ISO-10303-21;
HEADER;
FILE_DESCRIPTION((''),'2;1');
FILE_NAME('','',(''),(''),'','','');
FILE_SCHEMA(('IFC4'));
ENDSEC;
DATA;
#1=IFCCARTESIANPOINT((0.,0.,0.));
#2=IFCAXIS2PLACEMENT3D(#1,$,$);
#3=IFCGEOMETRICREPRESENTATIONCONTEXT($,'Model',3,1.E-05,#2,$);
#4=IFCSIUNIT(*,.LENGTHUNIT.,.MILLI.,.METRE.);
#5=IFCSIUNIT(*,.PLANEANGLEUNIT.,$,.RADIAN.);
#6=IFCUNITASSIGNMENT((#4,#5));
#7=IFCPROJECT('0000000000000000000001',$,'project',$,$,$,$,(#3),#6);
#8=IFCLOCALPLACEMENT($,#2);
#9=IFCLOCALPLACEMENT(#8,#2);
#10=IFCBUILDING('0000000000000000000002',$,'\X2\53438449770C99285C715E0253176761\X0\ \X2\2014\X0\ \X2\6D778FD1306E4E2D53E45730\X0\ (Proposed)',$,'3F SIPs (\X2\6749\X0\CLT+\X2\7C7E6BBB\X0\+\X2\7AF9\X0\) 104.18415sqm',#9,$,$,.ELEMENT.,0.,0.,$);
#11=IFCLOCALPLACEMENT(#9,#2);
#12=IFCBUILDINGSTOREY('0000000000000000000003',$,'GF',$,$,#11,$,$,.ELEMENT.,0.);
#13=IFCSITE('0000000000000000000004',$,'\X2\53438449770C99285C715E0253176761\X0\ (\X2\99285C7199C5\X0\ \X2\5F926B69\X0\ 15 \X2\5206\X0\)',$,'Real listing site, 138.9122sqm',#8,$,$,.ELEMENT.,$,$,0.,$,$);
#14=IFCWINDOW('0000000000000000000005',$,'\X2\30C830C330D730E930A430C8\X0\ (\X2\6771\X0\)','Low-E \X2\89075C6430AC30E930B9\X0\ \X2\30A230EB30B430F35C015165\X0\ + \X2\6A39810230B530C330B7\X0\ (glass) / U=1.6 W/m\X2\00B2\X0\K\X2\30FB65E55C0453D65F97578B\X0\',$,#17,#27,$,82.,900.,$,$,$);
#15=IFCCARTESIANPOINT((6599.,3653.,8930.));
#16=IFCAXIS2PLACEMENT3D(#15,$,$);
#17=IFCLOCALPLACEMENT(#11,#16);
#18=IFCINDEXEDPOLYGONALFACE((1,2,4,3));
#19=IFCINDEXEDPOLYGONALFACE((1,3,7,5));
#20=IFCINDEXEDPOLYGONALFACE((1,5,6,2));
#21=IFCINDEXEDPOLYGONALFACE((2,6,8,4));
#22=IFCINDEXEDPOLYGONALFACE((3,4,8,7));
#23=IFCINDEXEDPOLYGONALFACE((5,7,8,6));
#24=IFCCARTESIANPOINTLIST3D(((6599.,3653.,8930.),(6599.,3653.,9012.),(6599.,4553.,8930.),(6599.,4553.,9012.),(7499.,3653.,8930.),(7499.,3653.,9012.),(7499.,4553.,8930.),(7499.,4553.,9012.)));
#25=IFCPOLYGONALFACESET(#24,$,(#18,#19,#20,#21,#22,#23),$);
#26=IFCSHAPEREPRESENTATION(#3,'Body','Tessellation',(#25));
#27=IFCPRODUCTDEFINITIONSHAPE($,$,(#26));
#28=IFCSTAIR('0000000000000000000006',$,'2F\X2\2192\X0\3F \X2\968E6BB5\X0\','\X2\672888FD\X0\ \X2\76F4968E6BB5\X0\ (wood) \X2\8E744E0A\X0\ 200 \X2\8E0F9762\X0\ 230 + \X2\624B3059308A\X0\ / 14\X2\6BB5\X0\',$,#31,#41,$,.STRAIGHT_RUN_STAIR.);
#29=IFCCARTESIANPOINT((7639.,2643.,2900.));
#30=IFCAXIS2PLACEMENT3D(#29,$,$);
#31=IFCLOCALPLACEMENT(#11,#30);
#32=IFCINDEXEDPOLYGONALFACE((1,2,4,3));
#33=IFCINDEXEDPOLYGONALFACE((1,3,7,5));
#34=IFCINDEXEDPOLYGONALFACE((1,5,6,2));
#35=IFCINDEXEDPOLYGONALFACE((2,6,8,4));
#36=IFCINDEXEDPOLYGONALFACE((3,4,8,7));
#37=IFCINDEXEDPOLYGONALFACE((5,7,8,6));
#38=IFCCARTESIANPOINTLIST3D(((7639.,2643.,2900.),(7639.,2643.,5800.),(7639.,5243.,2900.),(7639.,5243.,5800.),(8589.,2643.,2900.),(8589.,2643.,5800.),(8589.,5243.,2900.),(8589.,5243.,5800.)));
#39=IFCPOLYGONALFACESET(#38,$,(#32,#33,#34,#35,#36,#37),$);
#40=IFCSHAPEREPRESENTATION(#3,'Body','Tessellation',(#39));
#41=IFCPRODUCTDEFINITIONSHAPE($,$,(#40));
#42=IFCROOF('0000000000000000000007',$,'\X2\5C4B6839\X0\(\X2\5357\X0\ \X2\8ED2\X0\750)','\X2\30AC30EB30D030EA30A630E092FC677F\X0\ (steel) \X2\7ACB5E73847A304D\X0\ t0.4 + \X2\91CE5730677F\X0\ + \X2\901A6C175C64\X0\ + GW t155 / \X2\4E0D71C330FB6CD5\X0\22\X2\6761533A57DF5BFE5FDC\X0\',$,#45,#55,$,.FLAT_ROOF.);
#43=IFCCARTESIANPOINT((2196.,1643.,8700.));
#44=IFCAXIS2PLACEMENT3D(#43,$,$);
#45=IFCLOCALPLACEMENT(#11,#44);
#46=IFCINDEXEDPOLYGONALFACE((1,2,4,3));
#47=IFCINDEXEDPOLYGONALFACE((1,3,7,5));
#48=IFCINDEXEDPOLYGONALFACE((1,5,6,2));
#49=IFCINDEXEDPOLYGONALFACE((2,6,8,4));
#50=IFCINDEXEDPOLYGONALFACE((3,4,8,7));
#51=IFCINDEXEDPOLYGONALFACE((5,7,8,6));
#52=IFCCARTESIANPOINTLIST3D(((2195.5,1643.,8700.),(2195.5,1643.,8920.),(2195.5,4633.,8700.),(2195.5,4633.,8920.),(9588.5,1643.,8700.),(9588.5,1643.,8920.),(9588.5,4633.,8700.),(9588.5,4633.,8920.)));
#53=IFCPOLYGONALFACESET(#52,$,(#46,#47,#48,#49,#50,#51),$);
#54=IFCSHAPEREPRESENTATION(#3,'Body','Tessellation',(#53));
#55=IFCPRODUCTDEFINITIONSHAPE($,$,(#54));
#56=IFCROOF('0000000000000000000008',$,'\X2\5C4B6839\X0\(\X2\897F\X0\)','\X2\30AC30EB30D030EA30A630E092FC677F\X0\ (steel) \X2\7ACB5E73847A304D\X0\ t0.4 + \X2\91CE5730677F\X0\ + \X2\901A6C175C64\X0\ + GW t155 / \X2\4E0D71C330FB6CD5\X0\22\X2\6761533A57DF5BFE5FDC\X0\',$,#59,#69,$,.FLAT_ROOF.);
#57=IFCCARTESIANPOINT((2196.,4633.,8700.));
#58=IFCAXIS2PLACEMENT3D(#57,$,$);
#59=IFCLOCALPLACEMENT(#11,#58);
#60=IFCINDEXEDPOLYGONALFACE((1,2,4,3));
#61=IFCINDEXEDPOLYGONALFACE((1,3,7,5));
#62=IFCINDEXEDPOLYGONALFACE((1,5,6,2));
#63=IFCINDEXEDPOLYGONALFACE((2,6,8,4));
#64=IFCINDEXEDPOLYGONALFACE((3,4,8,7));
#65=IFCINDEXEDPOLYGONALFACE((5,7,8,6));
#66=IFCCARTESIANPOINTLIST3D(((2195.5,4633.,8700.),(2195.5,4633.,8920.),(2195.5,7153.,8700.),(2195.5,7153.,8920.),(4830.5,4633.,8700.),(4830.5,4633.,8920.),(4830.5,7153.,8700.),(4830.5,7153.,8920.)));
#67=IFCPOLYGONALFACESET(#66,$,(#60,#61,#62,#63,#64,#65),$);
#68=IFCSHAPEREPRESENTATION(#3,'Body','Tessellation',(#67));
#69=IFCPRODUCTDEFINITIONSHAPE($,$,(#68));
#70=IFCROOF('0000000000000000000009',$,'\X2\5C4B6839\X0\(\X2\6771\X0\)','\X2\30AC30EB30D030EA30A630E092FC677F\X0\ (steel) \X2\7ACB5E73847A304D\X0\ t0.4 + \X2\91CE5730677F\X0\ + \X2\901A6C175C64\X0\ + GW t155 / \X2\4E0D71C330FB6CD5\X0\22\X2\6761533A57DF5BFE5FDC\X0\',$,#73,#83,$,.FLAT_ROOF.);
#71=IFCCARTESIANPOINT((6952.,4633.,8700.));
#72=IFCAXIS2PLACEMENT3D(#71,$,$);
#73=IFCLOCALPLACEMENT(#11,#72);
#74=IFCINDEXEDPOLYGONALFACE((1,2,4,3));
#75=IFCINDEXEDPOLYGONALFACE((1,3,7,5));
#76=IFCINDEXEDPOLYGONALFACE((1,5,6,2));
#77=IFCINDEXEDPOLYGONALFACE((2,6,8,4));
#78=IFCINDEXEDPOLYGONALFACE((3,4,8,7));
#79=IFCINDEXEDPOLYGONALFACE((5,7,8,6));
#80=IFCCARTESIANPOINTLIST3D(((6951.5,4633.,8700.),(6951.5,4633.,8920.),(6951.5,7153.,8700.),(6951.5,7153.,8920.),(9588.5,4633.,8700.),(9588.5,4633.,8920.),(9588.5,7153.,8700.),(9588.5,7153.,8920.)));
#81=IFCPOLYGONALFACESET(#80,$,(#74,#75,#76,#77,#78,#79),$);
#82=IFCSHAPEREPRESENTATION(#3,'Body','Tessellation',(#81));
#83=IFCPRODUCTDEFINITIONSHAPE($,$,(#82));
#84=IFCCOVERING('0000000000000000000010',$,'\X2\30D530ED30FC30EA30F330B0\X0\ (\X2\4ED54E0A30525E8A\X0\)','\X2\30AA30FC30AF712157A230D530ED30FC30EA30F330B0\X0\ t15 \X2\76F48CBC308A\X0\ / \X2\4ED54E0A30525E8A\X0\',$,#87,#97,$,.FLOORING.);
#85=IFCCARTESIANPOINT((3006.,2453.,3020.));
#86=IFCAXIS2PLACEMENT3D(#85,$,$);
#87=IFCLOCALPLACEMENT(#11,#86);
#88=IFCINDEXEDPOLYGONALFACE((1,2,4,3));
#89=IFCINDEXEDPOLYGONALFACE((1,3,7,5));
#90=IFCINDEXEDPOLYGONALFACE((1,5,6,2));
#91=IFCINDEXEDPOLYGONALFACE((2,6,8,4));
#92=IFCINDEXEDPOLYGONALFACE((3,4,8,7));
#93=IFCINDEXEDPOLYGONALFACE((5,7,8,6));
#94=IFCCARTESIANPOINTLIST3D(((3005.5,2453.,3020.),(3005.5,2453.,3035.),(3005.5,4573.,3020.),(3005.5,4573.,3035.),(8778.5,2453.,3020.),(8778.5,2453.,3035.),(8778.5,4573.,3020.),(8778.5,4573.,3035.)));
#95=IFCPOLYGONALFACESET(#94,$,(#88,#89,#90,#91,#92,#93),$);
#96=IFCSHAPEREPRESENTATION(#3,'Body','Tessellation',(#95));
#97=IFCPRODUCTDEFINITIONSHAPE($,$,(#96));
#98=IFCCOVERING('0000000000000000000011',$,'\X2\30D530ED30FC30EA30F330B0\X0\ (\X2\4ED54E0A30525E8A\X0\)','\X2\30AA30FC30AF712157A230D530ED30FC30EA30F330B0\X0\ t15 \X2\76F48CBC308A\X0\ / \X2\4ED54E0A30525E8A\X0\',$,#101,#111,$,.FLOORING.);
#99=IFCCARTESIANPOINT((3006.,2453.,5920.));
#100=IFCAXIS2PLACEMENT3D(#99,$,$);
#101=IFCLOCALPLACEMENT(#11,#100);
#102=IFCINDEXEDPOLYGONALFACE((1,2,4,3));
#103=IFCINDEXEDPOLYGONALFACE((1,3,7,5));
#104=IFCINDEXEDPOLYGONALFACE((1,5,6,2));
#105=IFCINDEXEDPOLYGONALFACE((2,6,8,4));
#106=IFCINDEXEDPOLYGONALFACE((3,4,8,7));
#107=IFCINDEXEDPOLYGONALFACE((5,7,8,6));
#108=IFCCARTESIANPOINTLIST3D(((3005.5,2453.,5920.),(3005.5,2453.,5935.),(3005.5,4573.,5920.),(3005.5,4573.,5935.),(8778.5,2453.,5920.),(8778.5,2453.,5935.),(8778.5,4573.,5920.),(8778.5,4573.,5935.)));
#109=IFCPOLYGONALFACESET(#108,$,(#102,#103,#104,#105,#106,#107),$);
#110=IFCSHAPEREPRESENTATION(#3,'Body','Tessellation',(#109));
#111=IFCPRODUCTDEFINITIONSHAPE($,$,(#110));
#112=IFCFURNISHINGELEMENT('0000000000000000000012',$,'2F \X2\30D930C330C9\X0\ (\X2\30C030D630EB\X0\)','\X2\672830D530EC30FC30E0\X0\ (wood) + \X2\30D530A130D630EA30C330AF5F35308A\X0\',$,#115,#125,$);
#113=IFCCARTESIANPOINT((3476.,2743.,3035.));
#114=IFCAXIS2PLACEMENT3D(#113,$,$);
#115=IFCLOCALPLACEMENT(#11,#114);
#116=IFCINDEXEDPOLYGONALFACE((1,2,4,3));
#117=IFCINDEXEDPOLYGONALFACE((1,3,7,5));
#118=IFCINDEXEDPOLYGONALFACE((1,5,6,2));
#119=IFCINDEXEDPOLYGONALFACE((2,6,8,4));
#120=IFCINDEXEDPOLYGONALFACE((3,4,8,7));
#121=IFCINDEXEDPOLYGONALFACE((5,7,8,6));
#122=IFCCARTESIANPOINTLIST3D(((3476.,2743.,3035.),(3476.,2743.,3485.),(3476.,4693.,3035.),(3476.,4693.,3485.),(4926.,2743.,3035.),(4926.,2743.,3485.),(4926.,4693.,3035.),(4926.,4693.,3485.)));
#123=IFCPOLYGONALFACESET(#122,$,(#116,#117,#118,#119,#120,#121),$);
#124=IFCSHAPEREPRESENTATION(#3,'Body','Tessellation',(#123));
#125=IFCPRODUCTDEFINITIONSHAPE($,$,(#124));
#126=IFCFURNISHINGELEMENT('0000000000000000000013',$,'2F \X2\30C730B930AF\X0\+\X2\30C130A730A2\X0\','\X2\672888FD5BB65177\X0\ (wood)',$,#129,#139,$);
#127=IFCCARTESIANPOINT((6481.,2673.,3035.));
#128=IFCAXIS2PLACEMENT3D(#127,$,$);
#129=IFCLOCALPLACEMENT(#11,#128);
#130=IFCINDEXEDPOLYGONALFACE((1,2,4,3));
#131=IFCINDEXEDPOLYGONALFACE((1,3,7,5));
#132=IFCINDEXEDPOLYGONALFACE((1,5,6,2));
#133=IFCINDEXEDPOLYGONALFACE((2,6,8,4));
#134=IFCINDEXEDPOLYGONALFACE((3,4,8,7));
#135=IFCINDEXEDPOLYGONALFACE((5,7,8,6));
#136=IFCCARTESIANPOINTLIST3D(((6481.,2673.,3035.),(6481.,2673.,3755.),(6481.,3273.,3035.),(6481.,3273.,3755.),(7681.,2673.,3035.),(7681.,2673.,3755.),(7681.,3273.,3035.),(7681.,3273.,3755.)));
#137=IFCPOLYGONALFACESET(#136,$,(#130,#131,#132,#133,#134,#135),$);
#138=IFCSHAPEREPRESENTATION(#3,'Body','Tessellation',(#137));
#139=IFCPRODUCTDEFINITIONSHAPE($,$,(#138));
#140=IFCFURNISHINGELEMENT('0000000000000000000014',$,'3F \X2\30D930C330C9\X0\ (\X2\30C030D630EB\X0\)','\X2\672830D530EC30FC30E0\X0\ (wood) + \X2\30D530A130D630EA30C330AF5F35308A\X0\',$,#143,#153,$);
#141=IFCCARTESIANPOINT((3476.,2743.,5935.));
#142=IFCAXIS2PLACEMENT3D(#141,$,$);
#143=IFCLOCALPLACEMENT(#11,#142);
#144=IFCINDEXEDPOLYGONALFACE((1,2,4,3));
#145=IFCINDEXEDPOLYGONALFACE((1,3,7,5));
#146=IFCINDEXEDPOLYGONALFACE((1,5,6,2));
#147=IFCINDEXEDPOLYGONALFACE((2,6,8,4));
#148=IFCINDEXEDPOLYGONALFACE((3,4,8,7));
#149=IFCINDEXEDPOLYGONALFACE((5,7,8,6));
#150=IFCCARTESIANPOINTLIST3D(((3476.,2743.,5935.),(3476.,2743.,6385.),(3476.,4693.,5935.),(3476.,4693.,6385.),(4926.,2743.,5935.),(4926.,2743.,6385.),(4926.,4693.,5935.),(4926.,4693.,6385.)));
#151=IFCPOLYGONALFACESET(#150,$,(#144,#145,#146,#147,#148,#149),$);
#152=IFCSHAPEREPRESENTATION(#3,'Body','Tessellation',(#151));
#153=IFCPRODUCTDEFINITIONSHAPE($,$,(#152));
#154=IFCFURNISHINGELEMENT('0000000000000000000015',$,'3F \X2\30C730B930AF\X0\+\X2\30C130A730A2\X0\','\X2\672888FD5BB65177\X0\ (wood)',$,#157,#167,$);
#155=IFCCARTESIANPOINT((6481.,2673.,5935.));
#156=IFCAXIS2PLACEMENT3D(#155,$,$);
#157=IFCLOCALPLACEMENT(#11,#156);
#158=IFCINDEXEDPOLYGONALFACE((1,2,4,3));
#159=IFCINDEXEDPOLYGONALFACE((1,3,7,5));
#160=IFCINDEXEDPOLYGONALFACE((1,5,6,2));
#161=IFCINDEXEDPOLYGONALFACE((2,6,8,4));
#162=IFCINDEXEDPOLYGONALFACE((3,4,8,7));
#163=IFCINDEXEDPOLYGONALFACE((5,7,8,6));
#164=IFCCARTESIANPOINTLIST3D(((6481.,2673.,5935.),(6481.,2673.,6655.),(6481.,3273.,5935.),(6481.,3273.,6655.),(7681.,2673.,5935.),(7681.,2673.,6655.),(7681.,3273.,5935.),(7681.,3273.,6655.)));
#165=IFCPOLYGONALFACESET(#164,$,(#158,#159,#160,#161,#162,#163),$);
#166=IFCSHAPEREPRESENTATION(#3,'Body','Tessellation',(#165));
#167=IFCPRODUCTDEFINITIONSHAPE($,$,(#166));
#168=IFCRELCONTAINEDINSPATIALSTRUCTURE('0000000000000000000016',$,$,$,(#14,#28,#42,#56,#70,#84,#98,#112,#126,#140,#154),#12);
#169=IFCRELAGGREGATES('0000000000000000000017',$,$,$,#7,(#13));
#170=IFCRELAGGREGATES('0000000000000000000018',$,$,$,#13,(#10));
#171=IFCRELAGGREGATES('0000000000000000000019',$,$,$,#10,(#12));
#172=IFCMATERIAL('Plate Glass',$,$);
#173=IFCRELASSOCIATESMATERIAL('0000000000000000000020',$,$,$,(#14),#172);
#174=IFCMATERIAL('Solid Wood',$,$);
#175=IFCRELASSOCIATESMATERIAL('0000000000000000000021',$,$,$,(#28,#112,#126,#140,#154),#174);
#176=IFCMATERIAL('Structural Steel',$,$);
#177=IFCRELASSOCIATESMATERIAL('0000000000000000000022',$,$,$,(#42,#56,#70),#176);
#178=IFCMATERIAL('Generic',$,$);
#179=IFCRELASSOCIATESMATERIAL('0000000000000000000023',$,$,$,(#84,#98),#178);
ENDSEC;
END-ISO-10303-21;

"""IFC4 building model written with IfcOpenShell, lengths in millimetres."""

from ifc_helpers import new_model, si_unit, frame, frame_2d, origin, place, context, project, spatial, rectangle, extrude, material, element, save


model = new_model("IFC4")

# Units and contexts
model_context = context("Model", 3, precision=1e-05, world=origin())
ifc_project = project(units=[si_unit("LENGTHUNIT", "METRE", prefix="MILLI"), si_unit("PLANEANGLEUNIT", "RADIAN")], contexts=[model_context])

# Site, building, storey
site_placement = place(None, origin())
site = spatial("IfcSite", under=ifc_project, at=site_placement, Name="千葉県館山市北条 (館山駅 徒歩 15 分)", ObjectType="Real listing site, 138.9122sqm", CompositionType="ELEMENT", RefElevation=0.0)
building_placement = place(site_placement, origin())
building = spatial("IfcBuilding", under=site, at=building_placement, Name="千葉県館山市北条 — 海近の中古地 (Proposed)", ObjectType="3F SIPs (杉CLT+籾殻+竹) 104.18415sqm", CompositionType="ELEMENT", ElevationOfRefHeight=0.0, ElevationOfTerrain=0.0)
storey_placement = place(building_placement, origin())
storey = spatial("IfcBuildingStorey", under=building, at=storey_placement, Name="GF", CompositionType="ELEMENT", Elevation=0.0)

# Shared definitions
ifc_material_1 = material(Name="Solid Wood")

# Shared definitions
ifc_material_2 = material(Name="Plate Glass")

# Window
window_1_placement = place(storey_placement, frame((6599.0, 3653.0, 8930.0)))
element("IfcWindow", 1, at=window_1_placement, inside=storey, material=ifc_material_2, Name="トップライト (東)", Description="Low-E 複層ガラス アルゴン封入 + 樹脂サッシ (glass) / U=1.6 W/m²K・日射取得型", OverallHeight=82.0, OverallWidth=900.0, context=model_context, shape_type="SweptSolid", body=[
    extrude(rectangle(XDim=900.0, YDim=900.0, at=frame_2d((450.0, 450.0))), frame((6599.0, 3653.0, 8930.0)), (0.0, 0.0, 1.0), 82.0),
])

# Stair
stair_placement = place(storey_placement, frame((7639.0, 2643.0, 2900.0)))
element("IfcStair", 2, at=stair_placement, inside=storey, material=ifc_material_1, Name="2F→3F 階段", Description="木製 直階段 (wood) 蹴上 200 踏面 230 + 手すり / 14段", PredefinedType="STRAIGHT_RUN_STAIR", context=model_context, shape_type="SweptSolid", body=[
    extrude(rectangle(XDim=950.0, YDim=2600.0, at=frame_2d((475.0, 1300.0))), frame((7639.0, 2643.0, 2900.0)), (0.0, 0.0, 1.0), 2900.0),
])

# Roofs
ifc_material_3 = material(Name="Structural Steel")
roof_1_placement = place(storey_placement, frame((2196.0, 1643.0, 8700.0)))
element("IfcRoof", 3, at=roof_1_placement, inside=storey, material=ifc_material_3, Name="屋根(南 軒750)", Description="ガルバリウム鋼板 (steel) 立平葺き t0.4 + 野地板 + 通気層 + GW t155 / 不燃・法22条区域対応", PredefinedType="FLAT_ROOF", context=model_context, shape_type="SweptSolid", body=[
    extrude(rectangle(XDim=7393.0, YDim=2990.0, at=frame_2d((3696.0, 1495.0))), frame((2196.0, 1643.0, 8700.0)), (0.0, 0.0, 1.0), 220.0),
])
roof_2_placement = place(storey_placement, frame((2196.0, 4633.0, 8700.0)))
element("IfcRoof", 4, at=roof_2_placement, inside=storey, material=ifc_material_3, Name="屋根(西)", Description="ガルバリウム鋼板 (steel) 立平葺き t0.4 + 野地板 + 通気層 + GW t155 / 不燃・法22条区域対応", PredefinedType="FLAT_ROOF", context=model_context, shape_type="SweptSolid", body=[
    extrude(rectangle(XDim=2635.0, YDim=2520.0, at=frame_2d((1317.0, 1260.0))), frame((2196.0, 4633.0, 8700.0)), (0.0, 0.0, 1.0), 220.0),
])
roof_3_placement = place(storey_placement, frame((6952.0, 4633.0, 8700.0)))
element("IfcRoof", 5, at=roof_3_placement, inside=storey, material=ifc_material_3, Name="屋根(東)", Description="ガルバリウム鋼板 (steel) 立平葺き t0.4 + 野地板 + 通気層 + GW t155 / 不燃・法22条区域対応", PredefinedType="FLAT_ROOF", context=model_context, shape_type="SweptSolid", body=[
    extrude(rectangle(XDim=2637.0, YDim=2520.0, at=frame_2d((1318.0, 1260.0))), frame((6952.0, 4633.0, 8700.0)), (0.0, 0.0, 1.0), 220.0),
])

# Coverings
ifc_material_4 = material(Name="Generic")
covering_1_placement = place(storey_placement, frame((3006.0, 2453.0, 3020.0)))
element("IfcCovering", 6, at=covering_1_placement, inside=storey, material=ifc_material_4, Name="フローリング (仕上げ床)", Description="オーク無垢フローリング t15 直貼り / 仕上げ床", PredefinedType="FLOORING", context=model_context, shape_type="SweptSolid", body=[
    extrude(rectangle(XDim=5773.0, YDim=2120.0, at=frame_2d((2886.0, 1060.0))), frame((3006.0, 2453.0, 3020.0)), (0.0, 0.0, 1.0), 15.0),
])
covering_2_placement = place(storey_placement, frame((3006.0, 2453.0, 5920.0)))
element("IfcCovering", 7, at=covering_2_placement, inside=storey, material=ifc_material_4, Name="フローリング (仕上げ床)", Description="オーク無垢フローリング t15 直貼り / 仕上げ床", PredefinedType="FLOORING", context=model_context, shape_type="SweptSolid", body=[
    extrude(rectangle(XDim=5773.0, YDim=2120.0, at=frame_2d((2886.0, 1060.0))), frame((3006.0, 2453.0, 5920.0)), (0.0, 0.0, 1.0), 15.0),
])

# Furnishing elements
furnishing_1_placement = place(storey_placement, frame((3476.0, 2743.0, 3035.0)))
element("IfcFurnishingElement", 8, at=furnishing_1_placement, inside=storey, material=ifc_material_1, Name="2F ベッド (ダブル)", Description="木フレーム (wood) + ファブリック張り", context=model_context, shape_type="SweptSolid", body=[
    extrude(rectangle(XDim=1450.0, YDim=1950.0, at=frame_2d((725.0, 975.0))), frame((3476.0, 2743.0, 3035.0)), (0.0, 0.0, 1.0), 450.0),
])
furnishing_2_placement = place(storey_placement, frame((6481.0, 2673.0, 3035.0)))
element("IfcFurnishingElement", 9, at=furnishing_2_placement, inside=storey, material=ifc_material_1, Name="2F デスク+チェア", Description="木製家具 (wood)", context=model_context, shape_type="SweptSolid", body=[
    extrude(rectangle(XDim=1200.0, YDim=600.0, at=frame_2d((600.0, 300.0))), frame((6481.0, 2673.0, 3035.0)), (0.0, 0.0, 1.0), 720.0),
])
furnishing_3_placement = place(storey_placement, frame((3476.0, 2743.0, 5935.0)))
element("IfcFurnishingElement", 10, at=furnishing_3_placement, inside=storey, material=ifc_material_1, Name="3F ベッド (ダブル)", Description="木フレーム (wood) + ファブリック張り", context=model_context, shape_type="SweptSolid", body=[
    extrude(rectangle(XDim=1450.0, YDim=1950.0, at=frame_2d((725.0, 975.0))), frame((3476.0, 2743.0, 5935.0)), (0.0, 0.0, 1.0), 450.0),
])
furnishing_4_placement = place(storey_placement, frame((6481.0, 2673.0, 5935.0)))
element("IfcFurnishingElement", 11, at=furnishing_4_placement, inside=storey, material=ifc_material_1, Name="3F デスク+チェア", Description="木製家具 (wood)", context=model_context, shape_type="SweptSolid", body=[
    extrude(rectangle(XDim=1200.0, YDim=600.0, at=frame_2d((600.0, 300.0))), frame((6481.0, 2673.0, 5935.0)), (0.0, 0.0, 1.0), 720.0),
])

save(model, "model.ifc")
